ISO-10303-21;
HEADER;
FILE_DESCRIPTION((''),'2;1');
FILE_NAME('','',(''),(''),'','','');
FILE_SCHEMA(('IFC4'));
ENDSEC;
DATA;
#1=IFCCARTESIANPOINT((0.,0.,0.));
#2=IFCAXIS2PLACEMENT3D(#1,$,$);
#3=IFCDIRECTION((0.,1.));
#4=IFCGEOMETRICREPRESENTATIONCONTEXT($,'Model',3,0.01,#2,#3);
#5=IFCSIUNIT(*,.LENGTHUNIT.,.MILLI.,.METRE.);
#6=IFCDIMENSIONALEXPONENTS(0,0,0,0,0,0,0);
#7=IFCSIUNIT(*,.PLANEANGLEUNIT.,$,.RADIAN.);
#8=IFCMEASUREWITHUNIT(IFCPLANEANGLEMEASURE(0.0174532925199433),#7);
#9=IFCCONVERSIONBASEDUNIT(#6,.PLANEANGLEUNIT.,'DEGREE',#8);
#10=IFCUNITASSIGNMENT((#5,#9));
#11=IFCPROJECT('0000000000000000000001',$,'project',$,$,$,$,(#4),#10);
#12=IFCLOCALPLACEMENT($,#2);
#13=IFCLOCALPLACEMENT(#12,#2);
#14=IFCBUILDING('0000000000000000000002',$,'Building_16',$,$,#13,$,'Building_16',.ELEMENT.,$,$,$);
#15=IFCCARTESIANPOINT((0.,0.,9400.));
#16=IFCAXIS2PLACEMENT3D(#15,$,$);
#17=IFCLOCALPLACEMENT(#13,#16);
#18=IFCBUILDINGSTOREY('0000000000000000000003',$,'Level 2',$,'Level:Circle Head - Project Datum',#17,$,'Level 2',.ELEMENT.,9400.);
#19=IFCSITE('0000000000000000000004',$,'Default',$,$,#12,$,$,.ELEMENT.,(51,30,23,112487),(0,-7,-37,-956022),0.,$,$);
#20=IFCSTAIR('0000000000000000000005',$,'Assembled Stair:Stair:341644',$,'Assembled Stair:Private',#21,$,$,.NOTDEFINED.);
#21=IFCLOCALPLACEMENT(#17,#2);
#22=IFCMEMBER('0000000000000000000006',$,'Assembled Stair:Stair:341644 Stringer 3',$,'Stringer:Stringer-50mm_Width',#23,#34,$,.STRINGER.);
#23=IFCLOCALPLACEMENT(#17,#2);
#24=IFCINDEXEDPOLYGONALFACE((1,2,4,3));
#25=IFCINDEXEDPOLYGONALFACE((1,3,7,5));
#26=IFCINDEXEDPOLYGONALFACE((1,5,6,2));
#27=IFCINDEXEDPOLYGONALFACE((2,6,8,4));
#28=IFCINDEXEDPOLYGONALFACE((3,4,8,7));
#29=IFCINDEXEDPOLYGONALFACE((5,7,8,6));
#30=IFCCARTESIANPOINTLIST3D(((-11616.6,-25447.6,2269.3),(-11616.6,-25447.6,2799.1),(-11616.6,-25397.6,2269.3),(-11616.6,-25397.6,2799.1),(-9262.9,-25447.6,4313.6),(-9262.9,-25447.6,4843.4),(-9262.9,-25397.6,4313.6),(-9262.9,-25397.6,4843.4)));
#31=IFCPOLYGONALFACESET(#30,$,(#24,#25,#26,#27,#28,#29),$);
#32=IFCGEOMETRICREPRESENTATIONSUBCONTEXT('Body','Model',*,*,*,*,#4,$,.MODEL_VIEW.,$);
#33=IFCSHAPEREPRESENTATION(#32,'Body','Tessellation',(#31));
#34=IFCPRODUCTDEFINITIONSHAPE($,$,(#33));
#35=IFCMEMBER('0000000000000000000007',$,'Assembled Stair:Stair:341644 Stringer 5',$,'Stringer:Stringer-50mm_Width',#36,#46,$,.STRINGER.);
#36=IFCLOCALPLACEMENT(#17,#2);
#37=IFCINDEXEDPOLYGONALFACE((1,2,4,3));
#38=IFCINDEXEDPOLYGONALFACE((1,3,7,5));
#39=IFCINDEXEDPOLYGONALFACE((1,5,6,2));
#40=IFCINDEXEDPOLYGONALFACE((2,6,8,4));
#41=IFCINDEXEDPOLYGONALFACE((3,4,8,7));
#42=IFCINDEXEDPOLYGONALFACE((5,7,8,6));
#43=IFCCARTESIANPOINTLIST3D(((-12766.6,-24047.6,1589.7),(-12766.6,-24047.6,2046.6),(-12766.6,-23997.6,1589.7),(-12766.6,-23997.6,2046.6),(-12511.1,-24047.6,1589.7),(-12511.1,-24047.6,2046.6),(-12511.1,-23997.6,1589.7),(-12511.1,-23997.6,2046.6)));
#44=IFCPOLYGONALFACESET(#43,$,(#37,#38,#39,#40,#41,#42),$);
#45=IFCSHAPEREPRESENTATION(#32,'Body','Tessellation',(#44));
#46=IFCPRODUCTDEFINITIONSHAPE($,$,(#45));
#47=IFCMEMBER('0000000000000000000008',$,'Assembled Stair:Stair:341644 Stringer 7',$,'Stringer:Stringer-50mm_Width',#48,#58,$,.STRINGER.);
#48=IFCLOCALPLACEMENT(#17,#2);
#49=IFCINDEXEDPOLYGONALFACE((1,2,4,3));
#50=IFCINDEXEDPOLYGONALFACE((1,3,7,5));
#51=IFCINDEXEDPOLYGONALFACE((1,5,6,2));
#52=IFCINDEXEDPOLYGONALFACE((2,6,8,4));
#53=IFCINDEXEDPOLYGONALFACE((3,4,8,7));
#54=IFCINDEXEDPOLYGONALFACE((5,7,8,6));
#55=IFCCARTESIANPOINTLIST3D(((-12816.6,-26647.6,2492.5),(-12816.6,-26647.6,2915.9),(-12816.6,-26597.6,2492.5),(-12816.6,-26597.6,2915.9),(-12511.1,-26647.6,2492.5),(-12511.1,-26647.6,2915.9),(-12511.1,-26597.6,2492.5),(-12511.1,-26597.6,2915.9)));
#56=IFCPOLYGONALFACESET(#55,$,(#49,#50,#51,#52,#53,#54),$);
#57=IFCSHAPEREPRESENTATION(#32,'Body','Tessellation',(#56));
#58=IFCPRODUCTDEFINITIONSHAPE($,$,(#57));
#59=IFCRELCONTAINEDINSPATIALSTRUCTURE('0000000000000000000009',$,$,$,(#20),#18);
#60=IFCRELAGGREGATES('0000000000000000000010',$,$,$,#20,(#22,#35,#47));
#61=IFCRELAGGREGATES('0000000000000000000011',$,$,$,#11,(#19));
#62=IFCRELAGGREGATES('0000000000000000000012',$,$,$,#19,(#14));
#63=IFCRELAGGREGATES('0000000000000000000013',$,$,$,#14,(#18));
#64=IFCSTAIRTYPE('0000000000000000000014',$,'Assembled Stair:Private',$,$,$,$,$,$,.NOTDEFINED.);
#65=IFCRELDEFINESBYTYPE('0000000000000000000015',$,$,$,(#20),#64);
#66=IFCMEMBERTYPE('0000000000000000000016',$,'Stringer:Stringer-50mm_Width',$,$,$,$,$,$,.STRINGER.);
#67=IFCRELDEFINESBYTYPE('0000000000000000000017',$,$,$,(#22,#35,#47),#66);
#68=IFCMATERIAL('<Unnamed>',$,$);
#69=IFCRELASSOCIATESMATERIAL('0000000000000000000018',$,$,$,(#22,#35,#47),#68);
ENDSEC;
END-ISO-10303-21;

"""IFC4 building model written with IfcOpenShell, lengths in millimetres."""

from ifc_helpers import new_model, entity, si_unit, converted_unit, direction, frame, origin, place, context, subcontext, project, spatial, indexed_curve, outline, extrude, material, type_object, element, aggregate, save


model = new_model("IFC4")

# Units and contexts
model_context = context("Model", 3, precision=0.01, world=origin(), true_north=direction((0.0, 1.0)))
body_context = subcontext(model_context, "Body", "Model", "MODEL_VIEW")
ifc_project = project(units=[si_unit("LENGTHUNIT", "METRE", prefix="MILLI"), converted_unit("PLANEANGLEUNIT", "DEGREE", entity("IfcPlaneAngleMeasure", 0.0174532925199433), si_unit("PLANEANGLEUNIT", "RADIAN"), dimensions=[0, 0, 0, 0, 0, 0, 0])], contexts=[model_context])

# Site, building, storey
site_placement = place(None, origin())
site = spatial("IfcSite", under=ifc_project, at=site_placement, Name="Default", CompositionType="ELEMENT", RefLatitude=(51, 30, 23, 112487), RefLongitude=(0, -7, -37, -956022), RefElevation=0.0)
building_placement = place(site_placement, origin())
building = spatial("IfcBuilding", under=site, at=building_placement, Name="Building_16", LongName="Building_16", CompositionType="ELEMENT")
storey_placement = place(building_placement, frame((0.0, 0.0, 9400.0)))
storey = spatial("IfcBuildingStorey", under=building, at=storey_placement, Name="Level 2", ObjectType="Level:Circle Head - Project Datum", LongName="Level 2", CompositionType="ELEMENT", Elevation=9400.0)

# Stair, members
stair_type = type_object("IfcStairType", Name="Assembled Stair:Private", PredefinedType="NOTDEFINED")
stair_placement = place(storey_placement, origin())
stair = element("IfcStair", 1, at=stair_placement, inside=storey, type_object=stair_type, Name="Assembled Stair:Stair:341644", ObjectType="Assembled Stair:Private", PredefinedType="NOTDEFINED")
ifc_material_1 = material(Name="<Unnamed>")
member_type = type_object("IfcMemberType", Name="Stringer:Stringer-50mm_Width", PredefinedType="STRINGER")
member_1_placement = place(stair_placement, origin())
member_1 = element("IfcMember", 2, at=member_1_placement, type_object=member_type, material=ifc_material_1, Name="Assembled Stair:Stair:341644 Stringer 3", ObjectType="Stringer:Stringer-50mm_Width", PredefinedType="STRINGER", context=body_context, shape_type="SweptSolid", body=[
    extrude(outline(indexed_curve([(-1385.1, -200.0), (1732.5, -200.0), (1385.1, 200.0), (-1732.5, 200.0), (-1385.1, -200.0)], self_intersect=False)), frame((-10439.8, -25447.6, 3556.4), z_axis=(0.0, 1.0, 0.0), x_axis=(0.754989, 0.0, 0.655738)), (0.0, 0.0, 1.0), 50.0),
])
member_2_placement = place(stair_placement, origin())
member_2 = element("IfcMember", 3, at=member_2_placement, type_object=member_type, material=ifc_material_1, Name="Assembled Stair:Stair:341644 Stringer 5", ObjectType="Stringer:Stringer-50mm_Width", PredefinedType="STRINGER", context=body_context, shape_type="SweptSolid", body=[
    extrude(outline(indexed_curve([(-127.7, -25.0), (127.7, -25.0), (127.7, 25.0), (-127.7, 25.0), (-127.7, -25.0)], self_intersect=False)), frame((-12638.9, -24022.6, 1589.7), z_axis=(0.0, 0.0, 1.0), x_axis=(-1.0, 0.0, 0.0)), (0.0, 0.0, 1.0), 456.9),
])
member_3_placement = place(stair_placement, origin())
member_3 = element("IfcMember", 4, at=member_3_placement, type_object=member_type, material=ifc_material_1, Name="Assembled Stair:Stair:341644 Stringer 7", ObjectType="Stringer:Stringer-50mm_Width", PredefinedType="STRINGER", context=body_context, shape_type="SweptSolid", body=[
    extrude(outline(indexed_curve([(-152.7, -25.0), (152.7, -25.0), (152.7, 25.0), (-152.7, 25.0), (-152.7, -25.0)], self_intersect=False)), frame((-12663.9, -26622.6, 2492.5)), (0.0, 0.0, 1.0), 423.4),
])
aggregate(stair, [member_1, member_2, member_3])

save(model, "model.ifc")
